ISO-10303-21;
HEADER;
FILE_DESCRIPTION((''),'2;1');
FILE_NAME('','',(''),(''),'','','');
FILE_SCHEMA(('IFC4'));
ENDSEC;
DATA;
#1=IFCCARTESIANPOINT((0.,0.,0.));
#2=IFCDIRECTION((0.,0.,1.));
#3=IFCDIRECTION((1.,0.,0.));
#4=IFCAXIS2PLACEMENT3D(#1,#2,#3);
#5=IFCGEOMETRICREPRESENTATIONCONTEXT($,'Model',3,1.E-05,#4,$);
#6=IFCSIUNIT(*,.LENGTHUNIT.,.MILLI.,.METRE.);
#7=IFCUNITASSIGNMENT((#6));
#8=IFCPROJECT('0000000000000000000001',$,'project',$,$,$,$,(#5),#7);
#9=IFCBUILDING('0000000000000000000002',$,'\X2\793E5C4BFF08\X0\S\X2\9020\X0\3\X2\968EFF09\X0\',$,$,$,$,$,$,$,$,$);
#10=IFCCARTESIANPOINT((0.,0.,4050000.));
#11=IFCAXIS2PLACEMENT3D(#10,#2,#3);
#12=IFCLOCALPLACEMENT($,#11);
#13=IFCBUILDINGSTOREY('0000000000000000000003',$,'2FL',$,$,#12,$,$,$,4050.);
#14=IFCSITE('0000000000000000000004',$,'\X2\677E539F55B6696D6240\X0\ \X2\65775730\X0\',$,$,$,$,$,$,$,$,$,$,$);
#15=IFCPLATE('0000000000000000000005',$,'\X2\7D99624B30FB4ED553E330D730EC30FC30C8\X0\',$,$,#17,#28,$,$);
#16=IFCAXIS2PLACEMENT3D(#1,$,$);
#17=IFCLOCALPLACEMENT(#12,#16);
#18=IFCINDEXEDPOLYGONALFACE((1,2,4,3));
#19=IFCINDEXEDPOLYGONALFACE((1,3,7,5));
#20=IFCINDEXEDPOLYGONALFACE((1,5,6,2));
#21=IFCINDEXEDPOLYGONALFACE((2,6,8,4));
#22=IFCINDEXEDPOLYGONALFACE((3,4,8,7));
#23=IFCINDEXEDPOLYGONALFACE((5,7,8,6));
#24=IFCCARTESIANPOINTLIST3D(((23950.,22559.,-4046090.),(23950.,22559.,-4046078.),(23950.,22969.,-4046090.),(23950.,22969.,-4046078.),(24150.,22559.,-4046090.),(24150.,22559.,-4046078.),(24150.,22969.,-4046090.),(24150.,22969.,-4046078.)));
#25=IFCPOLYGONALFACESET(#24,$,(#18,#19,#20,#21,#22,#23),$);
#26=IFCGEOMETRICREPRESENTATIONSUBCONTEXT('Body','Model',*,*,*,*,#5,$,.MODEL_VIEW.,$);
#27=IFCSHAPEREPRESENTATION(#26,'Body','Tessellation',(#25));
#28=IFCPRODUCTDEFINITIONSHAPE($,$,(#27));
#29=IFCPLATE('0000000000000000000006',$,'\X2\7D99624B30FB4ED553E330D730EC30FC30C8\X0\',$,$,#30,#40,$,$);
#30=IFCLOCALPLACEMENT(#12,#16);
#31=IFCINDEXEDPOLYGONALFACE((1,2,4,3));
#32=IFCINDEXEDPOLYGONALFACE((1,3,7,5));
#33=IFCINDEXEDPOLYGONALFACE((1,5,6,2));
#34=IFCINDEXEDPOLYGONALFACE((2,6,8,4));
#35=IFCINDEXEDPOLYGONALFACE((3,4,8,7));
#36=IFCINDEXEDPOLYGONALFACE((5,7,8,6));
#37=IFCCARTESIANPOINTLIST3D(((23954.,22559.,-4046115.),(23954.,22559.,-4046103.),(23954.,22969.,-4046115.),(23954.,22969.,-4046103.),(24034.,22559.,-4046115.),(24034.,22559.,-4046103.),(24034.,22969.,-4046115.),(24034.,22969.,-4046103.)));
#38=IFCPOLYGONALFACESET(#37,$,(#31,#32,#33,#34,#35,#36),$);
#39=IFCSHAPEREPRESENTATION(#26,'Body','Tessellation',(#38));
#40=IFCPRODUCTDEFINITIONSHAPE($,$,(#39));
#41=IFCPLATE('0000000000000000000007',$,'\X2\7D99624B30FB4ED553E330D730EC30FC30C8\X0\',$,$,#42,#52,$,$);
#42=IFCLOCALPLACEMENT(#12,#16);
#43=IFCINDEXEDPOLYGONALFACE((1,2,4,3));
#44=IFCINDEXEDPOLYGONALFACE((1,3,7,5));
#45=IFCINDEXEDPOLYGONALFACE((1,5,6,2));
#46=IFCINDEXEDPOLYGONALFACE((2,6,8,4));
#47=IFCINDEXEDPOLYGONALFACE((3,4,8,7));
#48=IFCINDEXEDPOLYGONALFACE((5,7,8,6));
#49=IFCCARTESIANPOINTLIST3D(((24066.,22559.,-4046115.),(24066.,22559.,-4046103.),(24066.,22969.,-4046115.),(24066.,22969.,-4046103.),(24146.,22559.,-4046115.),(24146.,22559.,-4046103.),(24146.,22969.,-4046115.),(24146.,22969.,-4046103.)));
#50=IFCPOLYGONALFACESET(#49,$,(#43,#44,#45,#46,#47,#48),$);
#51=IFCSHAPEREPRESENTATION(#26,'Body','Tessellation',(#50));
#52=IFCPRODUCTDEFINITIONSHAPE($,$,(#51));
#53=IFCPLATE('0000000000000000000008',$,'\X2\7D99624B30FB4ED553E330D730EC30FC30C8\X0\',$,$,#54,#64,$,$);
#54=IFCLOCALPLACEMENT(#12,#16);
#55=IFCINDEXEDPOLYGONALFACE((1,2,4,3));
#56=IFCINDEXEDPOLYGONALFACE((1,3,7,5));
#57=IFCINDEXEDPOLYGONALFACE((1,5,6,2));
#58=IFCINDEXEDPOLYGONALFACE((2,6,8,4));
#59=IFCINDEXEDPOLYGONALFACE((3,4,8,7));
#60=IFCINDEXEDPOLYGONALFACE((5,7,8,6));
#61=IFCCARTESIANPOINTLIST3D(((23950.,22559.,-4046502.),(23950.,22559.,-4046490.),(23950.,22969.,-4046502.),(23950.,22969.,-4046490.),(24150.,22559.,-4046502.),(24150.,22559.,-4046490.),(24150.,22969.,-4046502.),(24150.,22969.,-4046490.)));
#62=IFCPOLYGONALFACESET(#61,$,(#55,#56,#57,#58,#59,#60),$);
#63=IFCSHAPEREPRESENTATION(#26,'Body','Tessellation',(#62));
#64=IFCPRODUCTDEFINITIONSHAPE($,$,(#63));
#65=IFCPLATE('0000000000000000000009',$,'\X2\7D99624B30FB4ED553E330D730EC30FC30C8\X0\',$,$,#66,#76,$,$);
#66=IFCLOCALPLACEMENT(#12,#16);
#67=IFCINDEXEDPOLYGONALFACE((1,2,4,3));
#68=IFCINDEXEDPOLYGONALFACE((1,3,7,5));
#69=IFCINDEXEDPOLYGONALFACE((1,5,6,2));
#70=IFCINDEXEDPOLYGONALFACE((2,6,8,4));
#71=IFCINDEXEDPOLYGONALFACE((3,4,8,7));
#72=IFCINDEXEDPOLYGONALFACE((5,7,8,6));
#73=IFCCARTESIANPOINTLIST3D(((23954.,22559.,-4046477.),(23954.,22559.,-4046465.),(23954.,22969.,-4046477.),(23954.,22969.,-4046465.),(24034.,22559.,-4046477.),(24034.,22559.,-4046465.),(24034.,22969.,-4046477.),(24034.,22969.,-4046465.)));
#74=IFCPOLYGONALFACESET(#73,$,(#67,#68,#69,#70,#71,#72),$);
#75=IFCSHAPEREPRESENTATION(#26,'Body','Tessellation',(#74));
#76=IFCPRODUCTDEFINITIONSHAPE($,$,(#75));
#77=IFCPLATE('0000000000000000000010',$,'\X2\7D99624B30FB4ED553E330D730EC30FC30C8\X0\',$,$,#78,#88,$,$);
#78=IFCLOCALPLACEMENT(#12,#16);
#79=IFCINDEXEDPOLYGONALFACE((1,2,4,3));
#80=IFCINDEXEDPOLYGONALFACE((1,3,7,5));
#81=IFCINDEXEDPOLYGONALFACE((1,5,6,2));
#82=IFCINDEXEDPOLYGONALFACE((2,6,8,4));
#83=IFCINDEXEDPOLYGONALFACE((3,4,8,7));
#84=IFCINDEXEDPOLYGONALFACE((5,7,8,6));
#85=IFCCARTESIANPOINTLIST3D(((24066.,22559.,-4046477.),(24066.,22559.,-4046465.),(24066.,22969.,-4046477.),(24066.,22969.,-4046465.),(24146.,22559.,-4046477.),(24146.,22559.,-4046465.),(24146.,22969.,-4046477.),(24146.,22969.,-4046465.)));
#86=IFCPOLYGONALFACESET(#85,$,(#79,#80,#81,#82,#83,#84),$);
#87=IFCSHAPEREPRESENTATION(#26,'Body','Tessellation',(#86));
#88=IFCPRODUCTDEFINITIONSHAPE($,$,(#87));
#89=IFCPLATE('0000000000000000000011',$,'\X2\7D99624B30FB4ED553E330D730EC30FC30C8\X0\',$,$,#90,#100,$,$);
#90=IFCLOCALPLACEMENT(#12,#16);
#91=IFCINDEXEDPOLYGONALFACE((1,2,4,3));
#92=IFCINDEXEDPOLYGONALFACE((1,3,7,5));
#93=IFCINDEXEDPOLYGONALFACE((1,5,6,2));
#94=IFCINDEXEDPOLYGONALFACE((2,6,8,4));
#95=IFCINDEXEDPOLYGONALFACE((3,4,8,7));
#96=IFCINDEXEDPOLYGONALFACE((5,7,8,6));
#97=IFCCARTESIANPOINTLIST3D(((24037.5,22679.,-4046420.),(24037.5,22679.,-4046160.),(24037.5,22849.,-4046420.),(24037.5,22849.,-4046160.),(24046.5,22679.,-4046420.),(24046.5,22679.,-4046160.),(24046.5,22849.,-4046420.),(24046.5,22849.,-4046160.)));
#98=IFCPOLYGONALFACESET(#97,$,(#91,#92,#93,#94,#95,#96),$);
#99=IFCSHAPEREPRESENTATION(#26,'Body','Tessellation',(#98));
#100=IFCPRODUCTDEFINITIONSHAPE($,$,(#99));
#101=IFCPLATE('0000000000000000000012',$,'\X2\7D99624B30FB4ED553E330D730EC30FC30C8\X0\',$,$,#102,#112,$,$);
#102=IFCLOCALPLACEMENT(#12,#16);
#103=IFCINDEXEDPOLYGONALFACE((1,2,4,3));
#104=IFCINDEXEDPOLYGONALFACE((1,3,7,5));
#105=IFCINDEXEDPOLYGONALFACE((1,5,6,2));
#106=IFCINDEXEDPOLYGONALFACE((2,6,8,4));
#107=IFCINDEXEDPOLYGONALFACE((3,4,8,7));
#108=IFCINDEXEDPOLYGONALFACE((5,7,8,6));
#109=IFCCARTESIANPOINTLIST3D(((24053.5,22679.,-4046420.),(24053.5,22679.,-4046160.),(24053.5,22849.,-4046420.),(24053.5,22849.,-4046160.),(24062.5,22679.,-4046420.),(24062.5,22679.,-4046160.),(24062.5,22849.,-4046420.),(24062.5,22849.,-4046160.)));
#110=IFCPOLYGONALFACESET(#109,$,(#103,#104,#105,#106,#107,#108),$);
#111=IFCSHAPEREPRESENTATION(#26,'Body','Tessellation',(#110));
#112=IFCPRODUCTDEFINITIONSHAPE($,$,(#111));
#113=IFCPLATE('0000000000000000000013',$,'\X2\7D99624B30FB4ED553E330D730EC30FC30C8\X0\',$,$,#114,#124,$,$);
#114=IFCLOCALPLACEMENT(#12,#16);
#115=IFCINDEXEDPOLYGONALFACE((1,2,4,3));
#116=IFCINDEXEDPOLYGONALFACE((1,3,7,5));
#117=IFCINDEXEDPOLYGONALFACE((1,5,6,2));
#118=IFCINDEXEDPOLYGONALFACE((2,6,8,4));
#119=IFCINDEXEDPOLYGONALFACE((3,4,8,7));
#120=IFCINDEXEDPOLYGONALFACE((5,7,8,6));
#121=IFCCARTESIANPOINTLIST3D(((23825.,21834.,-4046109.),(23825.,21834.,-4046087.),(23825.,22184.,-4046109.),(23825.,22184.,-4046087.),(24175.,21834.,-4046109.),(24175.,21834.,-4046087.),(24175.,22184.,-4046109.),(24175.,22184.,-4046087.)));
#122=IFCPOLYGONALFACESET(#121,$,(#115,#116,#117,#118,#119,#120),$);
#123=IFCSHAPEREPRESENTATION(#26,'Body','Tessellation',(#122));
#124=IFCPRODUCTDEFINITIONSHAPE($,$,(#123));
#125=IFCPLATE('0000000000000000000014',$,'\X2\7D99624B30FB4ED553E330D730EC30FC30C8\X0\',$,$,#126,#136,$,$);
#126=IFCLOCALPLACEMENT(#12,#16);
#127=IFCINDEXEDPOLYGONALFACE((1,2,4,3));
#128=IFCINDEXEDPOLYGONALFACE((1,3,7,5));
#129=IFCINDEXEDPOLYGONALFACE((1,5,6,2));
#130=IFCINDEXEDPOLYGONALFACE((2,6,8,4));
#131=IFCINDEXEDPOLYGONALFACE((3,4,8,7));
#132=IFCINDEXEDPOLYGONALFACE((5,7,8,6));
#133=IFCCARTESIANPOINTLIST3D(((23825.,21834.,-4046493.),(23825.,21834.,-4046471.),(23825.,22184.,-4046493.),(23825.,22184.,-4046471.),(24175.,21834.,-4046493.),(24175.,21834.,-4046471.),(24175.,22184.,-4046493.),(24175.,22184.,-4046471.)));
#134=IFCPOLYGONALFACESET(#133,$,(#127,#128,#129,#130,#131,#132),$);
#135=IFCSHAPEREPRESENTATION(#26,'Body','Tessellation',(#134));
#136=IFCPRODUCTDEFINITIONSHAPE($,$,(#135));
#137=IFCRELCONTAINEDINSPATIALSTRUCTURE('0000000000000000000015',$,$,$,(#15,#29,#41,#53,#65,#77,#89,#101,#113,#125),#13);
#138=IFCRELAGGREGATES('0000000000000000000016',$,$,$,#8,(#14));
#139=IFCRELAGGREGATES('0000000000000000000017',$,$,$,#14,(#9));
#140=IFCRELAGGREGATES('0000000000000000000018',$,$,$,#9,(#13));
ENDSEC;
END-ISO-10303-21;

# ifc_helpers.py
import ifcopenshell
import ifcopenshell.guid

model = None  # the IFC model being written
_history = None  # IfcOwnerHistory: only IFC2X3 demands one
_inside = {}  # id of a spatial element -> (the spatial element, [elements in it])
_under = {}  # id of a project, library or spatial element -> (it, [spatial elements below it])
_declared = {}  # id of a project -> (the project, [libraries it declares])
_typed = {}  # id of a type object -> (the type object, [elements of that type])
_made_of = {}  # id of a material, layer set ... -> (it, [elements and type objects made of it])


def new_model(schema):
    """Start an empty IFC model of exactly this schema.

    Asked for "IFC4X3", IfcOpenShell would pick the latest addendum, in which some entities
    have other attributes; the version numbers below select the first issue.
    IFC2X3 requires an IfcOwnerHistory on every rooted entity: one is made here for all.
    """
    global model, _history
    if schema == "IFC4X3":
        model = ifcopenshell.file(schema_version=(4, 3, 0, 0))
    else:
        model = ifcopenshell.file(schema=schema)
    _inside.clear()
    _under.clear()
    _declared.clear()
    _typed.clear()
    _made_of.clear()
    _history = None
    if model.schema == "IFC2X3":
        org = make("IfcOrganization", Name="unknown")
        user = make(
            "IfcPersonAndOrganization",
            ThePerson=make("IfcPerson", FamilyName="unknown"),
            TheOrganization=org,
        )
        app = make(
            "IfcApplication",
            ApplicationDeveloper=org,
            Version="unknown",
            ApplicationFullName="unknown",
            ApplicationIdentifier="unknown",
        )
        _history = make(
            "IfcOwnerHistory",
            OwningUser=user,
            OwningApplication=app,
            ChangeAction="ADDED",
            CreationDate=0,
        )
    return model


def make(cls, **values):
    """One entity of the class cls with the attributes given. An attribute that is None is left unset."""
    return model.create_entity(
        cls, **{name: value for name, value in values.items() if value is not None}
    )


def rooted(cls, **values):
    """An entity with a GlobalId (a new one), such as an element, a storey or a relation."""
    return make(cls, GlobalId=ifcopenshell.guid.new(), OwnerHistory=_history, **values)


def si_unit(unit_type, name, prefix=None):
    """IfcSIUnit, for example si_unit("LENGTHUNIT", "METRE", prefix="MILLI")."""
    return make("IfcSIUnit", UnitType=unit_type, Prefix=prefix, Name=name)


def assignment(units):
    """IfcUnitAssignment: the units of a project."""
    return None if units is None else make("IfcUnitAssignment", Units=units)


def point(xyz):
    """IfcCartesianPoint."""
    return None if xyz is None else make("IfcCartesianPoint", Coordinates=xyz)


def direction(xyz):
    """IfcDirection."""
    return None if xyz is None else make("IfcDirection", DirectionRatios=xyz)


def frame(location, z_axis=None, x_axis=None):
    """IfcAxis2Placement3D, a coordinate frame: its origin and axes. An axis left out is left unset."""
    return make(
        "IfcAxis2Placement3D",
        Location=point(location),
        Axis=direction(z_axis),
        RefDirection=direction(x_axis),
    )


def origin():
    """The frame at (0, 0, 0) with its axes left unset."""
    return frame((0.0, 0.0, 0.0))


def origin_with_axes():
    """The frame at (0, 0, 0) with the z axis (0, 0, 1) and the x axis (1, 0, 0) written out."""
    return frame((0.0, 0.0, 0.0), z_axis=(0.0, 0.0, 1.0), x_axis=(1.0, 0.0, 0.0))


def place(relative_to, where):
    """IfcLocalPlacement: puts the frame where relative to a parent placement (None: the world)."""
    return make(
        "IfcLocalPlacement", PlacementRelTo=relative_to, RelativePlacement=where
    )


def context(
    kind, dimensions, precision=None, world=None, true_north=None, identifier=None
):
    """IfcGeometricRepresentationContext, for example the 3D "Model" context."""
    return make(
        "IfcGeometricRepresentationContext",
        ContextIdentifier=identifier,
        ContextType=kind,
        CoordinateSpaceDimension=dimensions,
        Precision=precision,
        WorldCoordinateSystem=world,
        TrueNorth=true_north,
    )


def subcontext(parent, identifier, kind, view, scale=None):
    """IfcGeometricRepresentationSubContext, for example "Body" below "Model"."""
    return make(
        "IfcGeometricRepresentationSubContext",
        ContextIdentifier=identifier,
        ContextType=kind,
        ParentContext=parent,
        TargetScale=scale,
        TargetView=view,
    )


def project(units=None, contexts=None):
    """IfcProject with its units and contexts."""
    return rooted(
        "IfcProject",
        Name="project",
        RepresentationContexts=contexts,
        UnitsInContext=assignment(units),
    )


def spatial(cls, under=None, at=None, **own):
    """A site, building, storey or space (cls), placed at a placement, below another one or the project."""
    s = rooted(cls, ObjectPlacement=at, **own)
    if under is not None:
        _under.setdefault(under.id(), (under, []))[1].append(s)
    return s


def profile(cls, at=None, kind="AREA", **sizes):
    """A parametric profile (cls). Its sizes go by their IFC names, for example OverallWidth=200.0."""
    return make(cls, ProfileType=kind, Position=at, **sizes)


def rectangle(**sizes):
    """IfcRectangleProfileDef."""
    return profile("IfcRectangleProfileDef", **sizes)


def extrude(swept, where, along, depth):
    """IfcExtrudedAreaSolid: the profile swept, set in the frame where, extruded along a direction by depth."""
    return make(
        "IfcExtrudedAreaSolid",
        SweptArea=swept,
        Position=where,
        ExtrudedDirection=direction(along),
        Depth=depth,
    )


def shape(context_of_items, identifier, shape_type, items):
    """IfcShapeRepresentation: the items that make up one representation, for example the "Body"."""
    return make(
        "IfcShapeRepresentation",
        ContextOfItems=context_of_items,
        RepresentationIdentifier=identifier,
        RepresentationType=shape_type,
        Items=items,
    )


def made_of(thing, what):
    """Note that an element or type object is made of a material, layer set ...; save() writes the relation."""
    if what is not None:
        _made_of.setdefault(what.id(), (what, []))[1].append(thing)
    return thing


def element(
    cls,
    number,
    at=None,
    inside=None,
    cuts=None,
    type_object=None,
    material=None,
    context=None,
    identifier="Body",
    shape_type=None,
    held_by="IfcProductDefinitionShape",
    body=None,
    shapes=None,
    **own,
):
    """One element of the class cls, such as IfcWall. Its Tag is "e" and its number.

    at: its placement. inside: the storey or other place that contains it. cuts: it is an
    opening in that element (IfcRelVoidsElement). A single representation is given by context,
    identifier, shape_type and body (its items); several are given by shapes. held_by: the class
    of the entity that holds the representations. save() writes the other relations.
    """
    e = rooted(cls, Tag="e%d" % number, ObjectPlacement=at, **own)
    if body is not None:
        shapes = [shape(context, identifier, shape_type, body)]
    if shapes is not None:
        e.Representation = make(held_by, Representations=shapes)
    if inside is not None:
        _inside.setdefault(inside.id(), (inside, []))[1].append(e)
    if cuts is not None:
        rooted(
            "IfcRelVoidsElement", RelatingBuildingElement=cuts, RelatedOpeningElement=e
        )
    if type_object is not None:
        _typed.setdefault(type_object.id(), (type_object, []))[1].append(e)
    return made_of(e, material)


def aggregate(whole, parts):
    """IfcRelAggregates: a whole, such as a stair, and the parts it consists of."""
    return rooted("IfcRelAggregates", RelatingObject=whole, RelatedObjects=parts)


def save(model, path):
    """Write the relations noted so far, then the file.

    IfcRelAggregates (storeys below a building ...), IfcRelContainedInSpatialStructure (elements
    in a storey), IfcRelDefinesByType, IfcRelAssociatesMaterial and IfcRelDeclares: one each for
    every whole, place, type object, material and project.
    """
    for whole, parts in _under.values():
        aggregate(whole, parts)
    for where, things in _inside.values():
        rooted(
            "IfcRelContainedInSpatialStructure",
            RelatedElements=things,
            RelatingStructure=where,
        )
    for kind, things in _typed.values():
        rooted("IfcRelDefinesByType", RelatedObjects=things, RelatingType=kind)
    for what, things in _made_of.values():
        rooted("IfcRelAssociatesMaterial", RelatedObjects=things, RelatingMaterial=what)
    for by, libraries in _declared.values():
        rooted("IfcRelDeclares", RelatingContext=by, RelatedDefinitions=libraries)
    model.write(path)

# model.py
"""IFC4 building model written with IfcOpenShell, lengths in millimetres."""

from ifc_helpers import new_model, si_unit, frame, origin, origin_with_axes, place, context, subcontext, project, spatial, rectangle, extrude, element, save


model = new_model("IFC4")

# Units and contexts
model_context = context("Model", 3, precision=1e-05, world=origin_with_axes())
body_context = subcontext(model_context, "Body", "Model", "MODEL_VIEW")
ifc_project = project(units=[si_unit("LENGTHUNIT", "METRE", prefix="MILLI")], contexts=[model_context])

# Site, building, storey
site = spatial("IfcSite", under=ifc_project, Name="松原営業所 敷地")
building = spatial("IfcBuilding", under=site, Name="社屋（S造3階）")
storey_placement = place(None, frame((0.0, 0.0, 4050000.0), z_axis=(0.0, 0.0, 1.0), x_axis=(1.0, 0.0, 0.0)))
storey = spatial("IfcBuildingStorey", under=building, at=storey_placement, Name="2FL", Elevation=4050.0)

# Plates
plate_1_placement = place(storey_placement, frame((24050.0, 22559.0, -4046084.0), z_axis=(0.0, 1.0, 0.0), x_axis=(-1.0, 0.0, 0.0)))
element("IfcPlate", 1, at=plate_1_placement, inside=storey, Name="継手・仕口プレート", context=body_context, shape_type="SweptSolid", body=[
    extrude(rectangle(XDim=200.0, YDim=12.0), origin(), (0.0, 0.0, 1.0), 410.0),
])
for number, where, z_axis, x_axis, name in (
    (2, (23994.0, 22559.0, -4046109.0), (0.0, 1.0, 0.0), (-1.0, 0.0, 0.0), "継手・仕口プレート"),
    (3, (24106.0, 22559.0, -4046109.0), (0.0, 1.0, 0.0), (-1.0, 0.0, 0.0), "継手・仕口プレート"),
):
    element("IfcPlate", number, at=place(storey_placement, frame(where, z_axis=z_axis, x_axis=x_axis)), inside=storey, Name=name, context=body_context, shape_type="SweptSolid", body=[
        extrude(rectangle(XDim=80.0, YDim=12.0), origin(), (0.0, 0.0, 1.0), 410.0),
    ])
plate_2_placement = place(storey_placement, frame((24050.0, 22559.0, -4046496.0), z_axis=(0.0, 1.0, 0.0), x_axis=(-1.0, 0.0, 0.0)))
element("IfcPlate", 4, at=plate_2_placement, inside=storey, Name="継手・仕口プレート", context=body_context, shape_type="SweptSolid", body=[
    extrude(rectangle(XDim=200.0, YDim=12.0), origin(), (0.0, 0.0, 1.0), 410.0),
])
for number, where, z_axis, x_axis, name in (
    (5, (23994.0, 22559.0, -4046471.0), (0.0, 1.0, 0.0), (-1.0, 0.0, 0.0), "継手・仕口プレート"),
    (6, (24106.0, 22559.0, -4046471.0), (0.0, 1.0, 0.0), (-1.0, 0.0, 0.0), "継手・仕口プレート"),
):
    element("IfcPlate", number, at=place(storey_placement, frame(where, z_axis=z_axis, x_axis=x_axis)), inside=storey, Name=name, context=body_context, shape_type="SweptSolid", body=[
        extrude(rectangle(XDim=80.0, YDim=12.0), origin(), (0.0, 0.0, 1.0), 410.0),
    ])
for number, where, z_axis, x_axis, name in (
    (7, (24042.0, 22679.0, -4046290.0), (0.0, 1.0, 0.0), (-1.0, 0.0, 0.0), "継手・仕口プレート"),
    (8, (24058.0, 22679.0, -4046290.0), (0.0, 1.0, 0.0), (-1.0, 0.0, 0.0), "継手・仕口プレート"),
):
    element("IfcPlate", number, at=place(storey_placement, frame(where, z_axis=z_axis, x_axis=x_axis)), inside=storey, Name=name, context=body_context, shape_type="SweptSolid", body=[
        extrude(rectangle(XDim=9.0, YDim=260.0), origin(), (0.0, 0.0, 1.0), 170.0),
    ])
for number, where, z_axis, x_axis, name in (
    (9, (23825.0, 22009.0, -4046098.0), (1.0, 0.0, 0.0), (0.0, 1.0, 0.0), "継手・仕口プレート"),
    (10, (23825.0, 22009.0, -4046482.0), (1.0, 0.0, 0.0), (0.0, 1.0, 0.0), "継手・仕口プレート"),
):
    element("IfcPlate", number, at=place(storey_placement, frame(where, z_axis=z_axis, x_axis=x_axis)), inside=storey, Name=name, context=body_context, shape_type="SweptSolid", body=[
        extrude(rectangle(XDim=350.0, YDim=22.0), origin(), (0.0, 0.0, 1.0), 350.0),
    ])

save(model, "model.ifc")
